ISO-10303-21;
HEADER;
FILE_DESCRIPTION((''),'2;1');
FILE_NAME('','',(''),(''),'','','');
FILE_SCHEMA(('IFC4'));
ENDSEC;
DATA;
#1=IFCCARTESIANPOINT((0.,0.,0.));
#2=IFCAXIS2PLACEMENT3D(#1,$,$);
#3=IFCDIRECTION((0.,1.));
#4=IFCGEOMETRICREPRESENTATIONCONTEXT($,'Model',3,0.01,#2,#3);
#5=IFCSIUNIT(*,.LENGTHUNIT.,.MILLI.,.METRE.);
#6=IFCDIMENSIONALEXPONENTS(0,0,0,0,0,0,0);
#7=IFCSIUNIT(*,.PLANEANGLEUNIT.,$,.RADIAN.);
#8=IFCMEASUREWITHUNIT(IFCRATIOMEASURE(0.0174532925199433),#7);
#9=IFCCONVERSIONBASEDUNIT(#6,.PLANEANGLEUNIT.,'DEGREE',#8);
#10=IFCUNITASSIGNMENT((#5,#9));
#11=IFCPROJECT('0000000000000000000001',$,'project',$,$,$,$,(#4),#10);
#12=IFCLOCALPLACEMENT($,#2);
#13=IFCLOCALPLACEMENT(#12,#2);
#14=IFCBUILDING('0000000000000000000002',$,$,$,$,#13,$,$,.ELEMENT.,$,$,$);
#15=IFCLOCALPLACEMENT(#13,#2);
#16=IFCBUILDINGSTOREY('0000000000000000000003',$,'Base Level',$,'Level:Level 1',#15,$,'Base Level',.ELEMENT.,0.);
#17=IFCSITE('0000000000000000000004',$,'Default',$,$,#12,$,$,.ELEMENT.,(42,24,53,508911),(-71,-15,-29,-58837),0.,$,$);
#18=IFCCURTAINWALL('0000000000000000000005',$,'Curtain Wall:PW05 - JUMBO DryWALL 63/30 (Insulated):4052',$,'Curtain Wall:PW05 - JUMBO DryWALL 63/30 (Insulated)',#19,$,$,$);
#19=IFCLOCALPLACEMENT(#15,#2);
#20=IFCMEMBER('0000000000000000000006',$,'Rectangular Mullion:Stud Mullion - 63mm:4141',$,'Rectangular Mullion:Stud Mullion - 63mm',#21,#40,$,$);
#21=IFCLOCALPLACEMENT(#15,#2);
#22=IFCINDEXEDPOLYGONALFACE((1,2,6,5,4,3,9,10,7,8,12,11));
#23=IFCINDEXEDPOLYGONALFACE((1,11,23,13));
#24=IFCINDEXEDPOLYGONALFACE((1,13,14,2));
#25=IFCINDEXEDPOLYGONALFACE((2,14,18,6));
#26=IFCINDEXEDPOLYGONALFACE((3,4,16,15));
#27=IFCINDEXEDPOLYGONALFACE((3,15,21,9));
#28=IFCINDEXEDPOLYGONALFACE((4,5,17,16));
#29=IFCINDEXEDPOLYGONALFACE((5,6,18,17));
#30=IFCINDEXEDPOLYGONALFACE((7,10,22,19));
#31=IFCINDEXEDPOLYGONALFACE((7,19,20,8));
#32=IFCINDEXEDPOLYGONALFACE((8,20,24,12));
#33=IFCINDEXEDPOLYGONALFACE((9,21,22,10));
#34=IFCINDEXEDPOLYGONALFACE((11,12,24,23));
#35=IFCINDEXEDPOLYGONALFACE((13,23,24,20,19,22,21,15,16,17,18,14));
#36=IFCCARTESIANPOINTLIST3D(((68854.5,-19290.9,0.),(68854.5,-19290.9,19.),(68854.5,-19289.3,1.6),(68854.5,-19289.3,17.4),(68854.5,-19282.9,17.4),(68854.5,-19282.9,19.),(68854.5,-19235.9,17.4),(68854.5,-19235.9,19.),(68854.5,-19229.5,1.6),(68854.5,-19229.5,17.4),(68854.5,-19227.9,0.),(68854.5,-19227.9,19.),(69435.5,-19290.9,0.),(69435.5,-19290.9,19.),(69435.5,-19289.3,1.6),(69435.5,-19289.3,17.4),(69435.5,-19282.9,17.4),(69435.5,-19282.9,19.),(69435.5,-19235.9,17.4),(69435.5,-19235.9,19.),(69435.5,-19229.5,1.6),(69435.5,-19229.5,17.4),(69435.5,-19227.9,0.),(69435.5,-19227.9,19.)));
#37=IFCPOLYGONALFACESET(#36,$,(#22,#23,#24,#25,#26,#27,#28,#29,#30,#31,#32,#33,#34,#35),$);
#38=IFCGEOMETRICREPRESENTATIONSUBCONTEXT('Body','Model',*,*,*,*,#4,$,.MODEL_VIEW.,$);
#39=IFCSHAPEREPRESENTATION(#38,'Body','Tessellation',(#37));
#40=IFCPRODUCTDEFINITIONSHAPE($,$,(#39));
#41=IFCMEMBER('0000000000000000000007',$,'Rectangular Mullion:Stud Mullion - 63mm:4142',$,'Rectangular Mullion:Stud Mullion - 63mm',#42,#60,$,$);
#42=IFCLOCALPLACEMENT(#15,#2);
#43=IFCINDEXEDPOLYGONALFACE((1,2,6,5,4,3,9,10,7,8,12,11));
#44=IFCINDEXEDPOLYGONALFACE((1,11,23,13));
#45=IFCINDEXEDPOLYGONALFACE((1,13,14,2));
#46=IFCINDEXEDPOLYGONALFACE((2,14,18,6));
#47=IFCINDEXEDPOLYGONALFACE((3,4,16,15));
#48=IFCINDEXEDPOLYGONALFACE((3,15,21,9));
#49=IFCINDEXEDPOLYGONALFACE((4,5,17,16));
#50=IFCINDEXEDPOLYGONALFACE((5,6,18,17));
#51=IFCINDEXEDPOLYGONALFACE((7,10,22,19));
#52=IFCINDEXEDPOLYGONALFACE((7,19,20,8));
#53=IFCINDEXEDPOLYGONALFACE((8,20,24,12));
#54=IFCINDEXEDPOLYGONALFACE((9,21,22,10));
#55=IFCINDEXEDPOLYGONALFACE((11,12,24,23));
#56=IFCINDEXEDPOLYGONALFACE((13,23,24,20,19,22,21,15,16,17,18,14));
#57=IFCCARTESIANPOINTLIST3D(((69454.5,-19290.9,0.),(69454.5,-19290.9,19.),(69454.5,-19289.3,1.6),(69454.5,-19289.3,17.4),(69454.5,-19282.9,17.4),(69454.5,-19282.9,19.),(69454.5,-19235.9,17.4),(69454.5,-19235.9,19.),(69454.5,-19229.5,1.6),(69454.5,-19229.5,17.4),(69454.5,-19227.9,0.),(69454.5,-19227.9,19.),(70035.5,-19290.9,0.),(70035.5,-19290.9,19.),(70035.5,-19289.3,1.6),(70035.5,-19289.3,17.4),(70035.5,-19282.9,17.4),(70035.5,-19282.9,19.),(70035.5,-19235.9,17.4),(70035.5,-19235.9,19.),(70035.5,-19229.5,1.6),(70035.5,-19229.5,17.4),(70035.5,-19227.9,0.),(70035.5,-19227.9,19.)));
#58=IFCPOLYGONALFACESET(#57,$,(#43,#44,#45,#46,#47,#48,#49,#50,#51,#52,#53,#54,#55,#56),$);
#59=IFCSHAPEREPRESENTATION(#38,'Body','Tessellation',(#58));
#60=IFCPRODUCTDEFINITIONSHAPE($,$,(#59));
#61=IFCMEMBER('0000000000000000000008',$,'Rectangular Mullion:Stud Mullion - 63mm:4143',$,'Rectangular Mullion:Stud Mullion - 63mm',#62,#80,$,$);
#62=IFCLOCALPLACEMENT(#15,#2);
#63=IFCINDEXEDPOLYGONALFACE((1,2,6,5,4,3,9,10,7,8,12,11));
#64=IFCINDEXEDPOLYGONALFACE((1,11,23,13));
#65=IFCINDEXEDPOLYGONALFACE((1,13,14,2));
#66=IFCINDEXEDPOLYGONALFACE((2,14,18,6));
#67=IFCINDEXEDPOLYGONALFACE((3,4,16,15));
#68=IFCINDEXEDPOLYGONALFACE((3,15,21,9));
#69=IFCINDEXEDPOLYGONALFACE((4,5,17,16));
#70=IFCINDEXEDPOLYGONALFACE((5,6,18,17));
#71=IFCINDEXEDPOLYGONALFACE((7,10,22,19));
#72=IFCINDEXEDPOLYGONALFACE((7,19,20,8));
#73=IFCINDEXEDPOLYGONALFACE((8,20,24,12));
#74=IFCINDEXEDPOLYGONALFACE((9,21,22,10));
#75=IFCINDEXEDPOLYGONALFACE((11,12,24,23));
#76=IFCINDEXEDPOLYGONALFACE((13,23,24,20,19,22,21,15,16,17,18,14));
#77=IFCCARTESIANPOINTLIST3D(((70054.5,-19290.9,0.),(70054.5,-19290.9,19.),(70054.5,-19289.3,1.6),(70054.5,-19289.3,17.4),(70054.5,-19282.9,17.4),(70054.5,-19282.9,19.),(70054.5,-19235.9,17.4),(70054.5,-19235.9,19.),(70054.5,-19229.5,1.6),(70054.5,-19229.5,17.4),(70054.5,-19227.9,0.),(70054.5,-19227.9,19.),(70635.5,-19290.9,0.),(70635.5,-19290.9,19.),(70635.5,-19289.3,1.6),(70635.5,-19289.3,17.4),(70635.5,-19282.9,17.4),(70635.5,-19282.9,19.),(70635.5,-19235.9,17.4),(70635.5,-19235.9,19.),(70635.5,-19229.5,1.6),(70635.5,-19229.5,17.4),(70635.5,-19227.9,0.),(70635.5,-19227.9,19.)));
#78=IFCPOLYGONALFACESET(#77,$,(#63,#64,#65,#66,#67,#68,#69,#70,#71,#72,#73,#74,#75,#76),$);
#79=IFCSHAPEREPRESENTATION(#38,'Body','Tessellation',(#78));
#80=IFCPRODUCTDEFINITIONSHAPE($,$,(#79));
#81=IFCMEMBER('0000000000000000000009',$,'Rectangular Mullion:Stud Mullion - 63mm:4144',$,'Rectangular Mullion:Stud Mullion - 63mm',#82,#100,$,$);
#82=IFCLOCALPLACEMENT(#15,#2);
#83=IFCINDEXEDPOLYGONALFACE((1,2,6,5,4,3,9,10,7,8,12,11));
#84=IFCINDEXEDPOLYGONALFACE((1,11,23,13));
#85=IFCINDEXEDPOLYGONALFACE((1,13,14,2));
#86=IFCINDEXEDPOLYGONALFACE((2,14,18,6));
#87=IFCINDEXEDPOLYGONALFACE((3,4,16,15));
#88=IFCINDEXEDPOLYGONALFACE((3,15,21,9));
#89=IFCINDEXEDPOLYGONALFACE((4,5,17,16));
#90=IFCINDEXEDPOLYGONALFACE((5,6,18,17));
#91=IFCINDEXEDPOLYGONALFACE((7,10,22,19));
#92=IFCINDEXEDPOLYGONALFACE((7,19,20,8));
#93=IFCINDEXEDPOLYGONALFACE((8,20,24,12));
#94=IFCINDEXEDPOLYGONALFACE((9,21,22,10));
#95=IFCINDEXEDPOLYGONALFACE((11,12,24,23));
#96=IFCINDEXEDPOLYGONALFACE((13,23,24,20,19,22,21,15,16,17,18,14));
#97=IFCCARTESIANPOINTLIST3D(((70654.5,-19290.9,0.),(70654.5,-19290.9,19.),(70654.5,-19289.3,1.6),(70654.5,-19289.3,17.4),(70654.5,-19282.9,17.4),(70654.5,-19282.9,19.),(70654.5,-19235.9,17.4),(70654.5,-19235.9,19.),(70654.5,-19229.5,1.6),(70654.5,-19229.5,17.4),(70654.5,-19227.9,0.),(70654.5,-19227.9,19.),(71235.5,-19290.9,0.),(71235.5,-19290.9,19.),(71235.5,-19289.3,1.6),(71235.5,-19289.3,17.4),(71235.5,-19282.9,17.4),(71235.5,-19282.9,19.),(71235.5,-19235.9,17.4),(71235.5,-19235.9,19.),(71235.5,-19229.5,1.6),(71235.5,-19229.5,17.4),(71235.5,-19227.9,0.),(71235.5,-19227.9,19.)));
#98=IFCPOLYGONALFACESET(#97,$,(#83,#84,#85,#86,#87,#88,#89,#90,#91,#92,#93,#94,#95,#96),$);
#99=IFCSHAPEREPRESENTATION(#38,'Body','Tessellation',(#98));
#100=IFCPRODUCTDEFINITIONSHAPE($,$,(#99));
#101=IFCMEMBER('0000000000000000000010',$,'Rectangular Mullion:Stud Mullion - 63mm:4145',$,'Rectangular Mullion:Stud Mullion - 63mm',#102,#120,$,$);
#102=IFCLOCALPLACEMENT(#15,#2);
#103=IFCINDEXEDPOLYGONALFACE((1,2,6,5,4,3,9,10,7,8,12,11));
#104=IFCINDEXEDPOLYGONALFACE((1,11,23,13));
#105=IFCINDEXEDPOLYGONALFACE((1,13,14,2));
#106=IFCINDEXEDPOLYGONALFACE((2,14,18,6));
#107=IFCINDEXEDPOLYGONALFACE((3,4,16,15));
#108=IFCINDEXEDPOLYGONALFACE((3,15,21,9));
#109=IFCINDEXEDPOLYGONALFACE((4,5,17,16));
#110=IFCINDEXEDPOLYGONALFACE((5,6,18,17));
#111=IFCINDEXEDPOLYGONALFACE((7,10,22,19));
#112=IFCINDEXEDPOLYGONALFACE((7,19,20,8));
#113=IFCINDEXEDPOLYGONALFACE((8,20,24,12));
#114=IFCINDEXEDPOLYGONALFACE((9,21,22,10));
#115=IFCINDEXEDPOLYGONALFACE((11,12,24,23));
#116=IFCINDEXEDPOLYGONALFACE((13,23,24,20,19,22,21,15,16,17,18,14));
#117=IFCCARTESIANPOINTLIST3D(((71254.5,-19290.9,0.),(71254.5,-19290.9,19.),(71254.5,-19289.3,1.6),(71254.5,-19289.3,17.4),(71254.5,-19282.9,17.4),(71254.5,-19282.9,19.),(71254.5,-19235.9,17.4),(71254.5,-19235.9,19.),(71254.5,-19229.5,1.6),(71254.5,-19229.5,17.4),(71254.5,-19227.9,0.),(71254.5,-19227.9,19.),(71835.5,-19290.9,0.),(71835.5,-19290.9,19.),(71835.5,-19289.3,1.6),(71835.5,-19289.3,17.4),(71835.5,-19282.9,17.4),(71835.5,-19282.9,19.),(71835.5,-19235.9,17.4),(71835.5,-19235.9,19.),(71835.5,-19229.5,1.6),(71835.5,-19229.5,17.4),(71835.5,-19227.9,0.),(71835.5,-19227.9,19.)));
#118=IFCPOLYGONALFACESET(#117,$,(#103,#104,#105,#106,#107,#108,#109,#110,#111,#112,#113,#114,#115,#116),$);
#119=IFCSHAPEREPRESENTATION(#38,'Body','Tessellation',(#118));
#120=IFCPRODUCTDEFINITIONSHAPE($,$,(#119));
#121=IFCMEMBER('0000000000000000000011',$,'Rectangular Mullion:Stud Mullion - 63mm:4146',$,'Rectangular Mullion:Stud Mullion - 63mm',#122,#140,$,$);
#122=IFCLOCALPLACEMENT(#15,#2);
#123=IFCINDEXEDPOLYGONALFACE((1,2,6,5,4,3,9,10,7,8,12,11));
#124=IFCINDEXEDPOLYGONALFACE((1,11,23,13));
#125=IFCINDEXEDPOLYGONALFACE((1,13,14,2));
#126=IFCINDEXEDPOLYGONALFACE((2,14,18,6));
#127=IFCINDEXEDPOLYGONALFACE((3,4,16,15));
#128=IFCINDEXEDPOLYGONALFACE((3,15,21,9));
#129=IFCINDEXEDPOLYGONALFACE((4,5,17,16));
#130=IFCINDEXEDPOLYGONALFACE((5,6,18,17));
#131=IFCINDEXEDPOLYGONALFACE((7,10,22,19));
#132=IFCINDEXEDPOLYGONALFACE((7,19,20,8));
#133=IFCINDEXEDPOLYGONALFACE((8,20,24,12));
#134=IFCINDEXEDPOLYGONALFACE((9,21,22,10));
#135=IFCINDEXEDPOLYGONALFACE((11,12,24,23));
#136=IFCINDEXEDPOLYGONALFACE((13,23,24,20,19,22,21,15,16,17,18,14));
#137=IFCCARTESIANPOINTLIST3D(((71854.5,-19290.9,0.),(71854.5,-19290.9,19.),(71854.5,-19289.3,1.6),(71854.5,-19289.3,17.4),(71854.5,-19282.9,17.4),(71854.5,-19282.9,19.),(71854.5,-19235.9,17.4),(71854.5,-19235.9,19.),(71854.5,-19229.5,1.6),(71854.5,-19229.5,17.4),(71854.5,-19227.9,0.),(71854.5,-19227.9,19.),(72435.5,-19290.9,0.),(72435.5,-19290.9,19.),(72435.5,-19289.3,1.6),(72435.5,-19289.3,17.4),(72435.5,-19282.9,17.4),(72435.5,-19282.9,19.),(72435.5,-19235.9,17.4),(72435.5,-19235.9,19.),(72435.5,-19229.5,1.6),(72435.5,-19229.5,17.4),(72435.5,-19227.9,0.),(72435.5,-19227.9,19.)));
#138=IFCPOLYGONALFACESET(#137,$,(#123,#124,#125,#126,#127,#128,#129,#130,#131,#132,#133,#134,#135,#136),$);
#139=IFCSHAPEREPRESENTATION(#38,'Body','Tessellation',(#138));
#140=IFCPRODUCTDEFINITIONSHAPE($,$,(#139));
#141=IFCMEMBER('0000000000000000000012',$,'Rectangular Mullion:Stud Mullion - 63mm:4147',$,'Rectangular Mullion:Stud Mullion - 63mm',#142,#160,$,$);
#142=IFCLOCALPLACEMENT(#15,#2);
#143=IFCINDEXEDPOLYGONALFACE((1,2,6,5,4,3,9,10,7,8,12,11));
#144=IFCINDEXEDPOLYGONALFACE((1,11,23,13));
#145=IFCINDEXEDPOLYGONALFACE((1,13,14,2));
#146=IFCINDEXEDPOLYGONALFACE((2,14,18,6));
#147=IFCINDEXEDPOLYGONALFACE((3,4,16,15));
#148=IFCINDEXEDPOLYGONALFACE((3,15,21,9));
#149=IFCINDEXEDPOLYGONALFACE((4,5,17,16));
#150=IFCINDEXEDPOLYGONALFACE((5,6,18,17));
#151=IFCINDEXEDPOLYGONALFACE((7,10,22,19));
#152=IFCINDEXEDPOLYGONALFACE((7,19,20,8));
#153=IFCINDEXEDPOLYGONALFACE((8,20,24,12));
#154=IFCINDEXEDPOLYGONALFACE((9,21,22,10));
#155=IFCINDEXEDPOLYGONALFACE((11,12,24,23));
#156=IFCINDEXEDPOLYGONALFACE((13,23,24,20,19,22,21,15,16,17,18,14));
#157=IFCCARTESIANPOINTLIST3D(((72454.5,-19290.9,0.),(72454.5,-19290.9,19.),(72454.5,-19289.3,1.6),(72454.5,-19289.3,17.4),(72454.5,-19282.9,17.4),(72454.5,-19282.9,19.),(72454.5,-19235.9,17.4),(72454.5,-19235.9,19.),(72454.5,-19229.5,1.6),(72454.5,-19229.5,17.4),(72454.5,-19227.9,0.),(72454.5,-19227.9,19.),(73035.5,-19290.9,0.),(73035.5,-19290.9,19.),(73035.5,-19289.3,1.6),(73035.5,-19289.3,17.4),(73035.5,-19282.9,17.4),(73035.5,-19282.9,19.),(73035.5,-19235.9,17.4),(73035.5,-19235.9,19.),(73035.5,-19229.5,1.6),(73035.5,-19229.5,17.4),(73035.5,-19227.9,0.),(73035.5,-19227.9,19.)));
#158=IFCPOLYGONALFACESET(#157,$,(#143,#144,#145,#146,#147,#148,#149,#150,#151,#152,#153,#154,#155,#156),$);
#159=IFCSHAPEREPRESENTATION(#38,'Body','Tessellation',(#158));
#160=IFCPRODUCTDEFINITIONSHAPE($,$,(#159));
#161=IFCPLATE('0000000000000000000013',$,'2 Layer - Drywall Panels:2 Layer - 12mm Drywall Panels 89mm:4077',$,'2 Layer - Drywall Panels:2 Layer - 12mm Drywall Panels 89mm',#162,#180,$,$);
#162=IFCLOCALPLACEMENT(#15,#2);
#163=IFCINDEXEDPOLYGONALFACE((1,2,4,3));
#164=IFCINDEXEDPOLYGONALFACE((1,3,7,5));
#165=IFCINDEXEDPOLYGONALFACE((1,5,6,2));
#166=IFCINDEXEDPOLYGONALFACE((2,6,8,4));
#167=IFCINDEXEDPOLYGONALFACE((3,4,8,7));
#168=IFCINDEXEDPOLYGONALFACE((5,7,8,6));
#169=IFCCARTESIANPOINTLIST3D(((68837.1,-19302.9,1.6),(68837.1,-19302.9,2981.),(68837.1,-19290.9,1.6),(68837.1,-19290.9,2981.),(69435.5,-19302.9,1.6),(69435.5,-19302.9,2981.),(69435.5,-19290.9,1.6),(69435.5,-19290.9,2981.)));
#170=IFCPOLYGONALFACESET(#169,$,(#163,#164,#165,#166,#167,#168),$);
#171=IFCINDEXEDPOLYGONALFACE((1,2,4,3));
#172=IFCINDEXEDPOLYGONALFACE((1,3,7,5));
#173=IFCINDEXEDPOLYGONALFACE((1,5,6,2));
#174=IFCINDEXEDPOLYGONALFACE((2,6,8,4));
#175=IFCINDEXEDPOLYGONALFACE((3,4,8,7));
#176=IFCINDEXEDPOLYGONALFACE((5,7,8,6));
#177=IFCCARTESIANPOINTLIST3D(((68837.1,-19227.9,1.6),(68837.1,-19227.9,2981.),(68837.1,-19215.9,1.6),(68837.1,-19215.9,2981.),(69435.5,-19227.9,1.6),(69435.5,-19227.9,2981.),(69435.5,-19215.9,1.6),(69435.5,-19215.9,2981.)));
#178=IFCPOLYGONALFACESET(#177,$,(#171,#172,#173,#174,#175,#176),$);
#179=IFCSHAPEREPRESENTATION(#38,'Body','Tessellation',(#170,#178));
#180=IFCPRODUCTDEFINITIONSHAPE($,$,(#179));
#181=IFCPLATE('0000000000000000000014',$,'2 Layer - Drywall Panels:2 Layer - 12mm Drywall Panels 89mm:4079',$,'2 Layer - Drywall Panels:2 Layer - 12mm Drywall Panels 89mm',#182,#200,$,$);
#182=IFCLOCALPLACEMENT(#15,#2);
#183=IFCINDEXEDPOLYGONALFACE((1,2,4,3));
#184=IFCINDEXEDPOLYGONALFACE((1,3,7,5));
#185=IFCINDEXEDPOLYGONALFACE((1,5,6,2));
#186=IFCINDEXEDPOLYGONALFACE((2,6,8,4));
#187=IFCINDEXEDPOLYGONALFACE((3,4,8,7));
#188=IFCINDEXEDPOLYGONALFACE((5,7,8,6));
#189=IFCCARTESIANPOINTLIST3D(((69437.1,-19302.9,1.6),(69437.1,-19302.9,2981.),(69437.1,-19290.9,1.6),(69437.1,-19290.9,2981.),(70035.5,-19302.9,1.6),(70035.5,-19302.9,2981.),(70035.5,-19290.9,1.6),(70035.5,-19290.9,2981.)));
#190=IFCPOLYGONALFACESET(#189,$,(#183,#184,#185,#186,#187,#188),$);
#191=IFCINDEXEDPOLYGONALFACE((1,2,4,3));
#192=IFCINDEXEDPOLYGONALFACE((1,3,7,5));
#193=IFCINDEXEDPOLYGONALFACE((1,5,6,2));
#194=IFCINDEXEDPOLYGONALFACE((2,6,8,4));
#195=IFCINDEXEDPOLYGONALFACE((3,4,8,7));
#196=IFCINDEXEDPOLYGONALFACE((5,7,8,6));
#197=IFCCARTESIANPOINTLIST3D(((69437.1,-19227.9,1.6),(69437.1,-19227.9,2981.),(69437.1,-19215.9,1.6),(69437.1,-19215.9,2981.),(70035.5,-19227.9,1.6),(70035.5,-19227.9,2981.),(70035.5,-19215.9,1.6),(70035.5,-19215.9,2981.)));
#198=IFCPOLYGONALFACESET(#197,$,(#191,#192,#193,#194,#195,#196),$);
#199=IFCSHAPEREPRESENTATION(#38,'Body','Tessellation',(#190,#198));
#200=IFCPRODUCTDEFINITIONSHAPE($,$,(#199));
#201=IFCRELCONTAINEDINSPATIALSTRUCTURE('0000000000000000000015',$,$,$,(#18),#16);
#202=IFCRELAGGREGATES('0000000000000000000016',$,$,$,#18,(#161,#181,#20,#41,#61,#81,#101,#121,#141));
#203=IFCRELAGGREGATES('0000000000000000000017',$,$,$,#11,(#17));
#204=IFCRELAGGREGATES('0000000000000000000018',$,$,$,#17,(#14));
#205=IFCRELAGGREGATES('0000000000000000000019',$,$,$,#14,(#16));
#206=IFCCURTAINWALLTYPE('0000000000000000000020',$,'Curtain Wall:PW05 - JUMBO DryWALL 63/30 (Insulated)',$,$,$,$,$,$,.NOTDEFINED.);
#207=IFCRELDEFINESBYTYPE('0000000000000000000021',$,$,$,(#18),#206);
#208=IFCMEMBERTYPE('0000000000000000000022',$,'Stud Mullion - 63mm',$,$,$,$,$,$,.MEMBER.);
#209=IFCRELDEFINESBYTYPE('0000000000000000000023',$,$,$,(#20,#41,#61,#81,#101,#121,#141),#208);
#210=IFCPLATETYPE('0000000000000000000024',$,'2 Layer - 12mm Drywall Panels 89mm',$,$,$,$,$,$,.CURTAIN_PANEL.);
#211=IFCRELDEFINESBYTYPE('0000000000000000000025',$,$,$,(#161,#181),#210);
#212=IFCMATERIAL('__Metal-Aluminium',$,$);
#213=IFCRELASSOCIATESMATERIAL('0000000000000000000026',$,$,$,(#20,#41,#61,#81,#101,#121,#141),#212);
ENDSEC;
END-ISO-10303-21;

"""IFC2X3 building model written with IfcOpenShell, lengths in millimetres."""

from ifc_helpers import new_model, entity, si_unit, converted_unit, direction, frame, frame_2d, origin, place, context, subcontext, project, spatial, polyline, rectangle, outline, extrude, source, transform, mapped, material, type_object, type_shapes, element, aggregate, save


model = new_model("IFC2X3")

# Units and contexts
model_context = context("Model", 3, precision=0.01, world=origin(), true_north=direction((0.0, 1.0)))
body_context = subcontext(model_context, "Body", "Model", "MODEL_VIEW")
ifc_project = project(units=[si_unit("LENGTHUNIT", "METRE", prefix="MILLI"), converted_unit("PLANEANGLEUNIT", "DEGREE", entity("IfcRatioMeasure", 0.0174532925199433), si_unit("PLANEANGLEUNIT", "RADIAN"), dimensions=[0, 0, 0, 0, 0, 0, 0])], contexts=[model_context])

# Site, building, storey
site_placement = place(None, origin())
site = spatial("IfcSite", under=ifc_project, at=site_placement, Name="Default", CompositionType="ELEMENT", RefLatitude=(42, 24, 53, 508911), RefLongitude=(-71, -15, -29, -58837), RefElevation=0.0)
building_placement = place(site_placement, origin())
building = spatial("IfcBuilding", under=site, at=building_placement, CompositionType="ELEMENT")
storey_placement = place(building_placement, origin())
storey = spatial("IfcBuildingStorey", under=building, at=storey_placement, Name="Base Level", ObjectType="Level:Level 1", LongName="Base Level", CompositionType="ELEMENT", Elevation=0.0)

# Curtain wall, members, plates
curtain_wall_type = type_object("IfcCurtainWallType", Name="Curtain Wall:PW05 - JUMBO DryWALL 63/30 (Insulated)", PredefinedType="NOTDEFINED")
curtain_wall_placement = place(building_placement, origin())
curtain_wall = element("IfcCurtainWall", 1, at=curtain_wall_placement, inside=storey, type_object=curtain_wall_type, Name="Curtain Wall:PW05 - JUMBO DryWALL 63/30 (Insulated):4052", ObjectType="Curtain Wall:PW05 - JUMBO DryWALL 63/30 (Insulated)")
ifc_material = material(Name="__Metal-Aluminium")
member_type_1 = type_object("IfcMemberType", Name="Stud Mullion - 63mm", PredefinedType="MEMBER")
shared_shape_1 = source(origin(), body_context, "Body", "SweptSolid", [
    extrude(outline(polyline([(23.5, -6.6), (31.5, -6.6), (31.5, 12.4), (-31.5, 12.4), (-31.5, -6.6), (-23.5, -6.6), (-23.5, -5.0), (-29.9, -5.0), (-29.9, 10.8), (29.9, 10.8), (29.9, -5.0), (23.5, -5.0), (23.5, -6.6)])), frame((-12.4, 0.0, -581.0), z_axis=(0.0, 0.0, 1.0), x_axis=(0.0, -1.0, 0.0)), (0.0, 0.0, 1.0), 581.0),
])
type_shapes(member_type_1, [shared_shape_1])
member_1_placement = place(building_placement, frame((68854.5, -19259.4, 0.0), z_axis=(-1.0, 0.0, 0.0), x_axis=(0.0, 0.0, -1.0)))
member_1 = element("IfcMember", 2, at=member_1_placement, type_object=member_type_1, material=ifc_material, Name="Rectangular Mullion:Stud Mullion - 63mm:4141", ObjectType="Rectangular Mullion:Stud Mullion - 63mm", context=body_context, shape_type="MappedRepresentation", body=[
    mapped(shared_shape_1, transform((0.0, 0.0, 0.0), scale=1.0)),
])
member_2_placement = place(building_placement, frame((69454.5, -19259.4, 0.0), z_axis=(-1.0, 0.0, 0.0), x_axis=(0.0, 0.0, -1.0)))
member_2 = element("IfcMember", 3, at=member_2_placement, type_object=member_type_1, material=ifc_material, Name="Rectangular Mullion:Stud Mullion - 63mm:4142", ObjectType="Rectangular Mullion:Stud Mullion - 63mm", context=body_context, shape_type="MappedRepresentation", body=[
    mapped(shared_shape_1, transform((0.0, 0.0, 0.0), scale=1.0)),
])
member_3_placement = place(building_placement, frame((70054.5, -19259.4, 0.0), z_axis=(-1.0, 0.0, 0.0), x_axis=(0.0, 0.0, -1.0)))
member_3 = element("IfcMember", 4, at=member_3_placement, type_object=member_type_1, material=ifc_material, Name="Rectangular Mullion:Stud Mullion - 63mm:4143", ObjectType="Rectangular Mullion:Stud Mullion - 63mm", context=body_context, shape_type="MappedRepresentation", body=[
    mapped(shared_shape_1, transform((0.0, 0.0, 0.0), scale=1.0)),
])
member_4_placement = place(building_placement, frame((70654.5, -19259.4, 0.0), z_axis=(-1.0, 0.0, 0.0), x_axis=(0.0, 0.0, -1.0)))
member_4 = element("IfcMember", 5, at=member_4_placement, type_object=member_type_1, material=ifc_material, Name="Rectangular Mullion:Stud Mullion - 63mm:4144", ObjectType="Rectangular Mullion:Stud Mullion - 63mm", context=body_context, shape_type="MappedRepresentation", body=[
    mapped(shared_shape_1, transform((0.0, 0.0, 0.0), scale=1.0)),
])
member_5_placement = place(building_placement, frame((71254.5, -19259.4, 0.0), z_axis=(-1.0, 0.0, 0.0), x_axis=(0.0, 0.0, -1.0)))
member_5 = element("IfcMember", 6, at=member_5_placement, type_object=member_type_1, material=ifc_material, Name="Rectangular Mullion:Stud Mullion - 63mm:4145", ObjectType="Rectangular Mullion:Stud Mullion - 63mm", context=body_context, shape_type="MappedRepresentation", body=[
    mapped(shared_shape_1, transform((0.0, 0.0, 0.0), scale=1.0)),
])
member_6_placement = place(building_placement, frame((71854.5, -19259.4, 0.0), z_axis=(-1.0, 0.0, 0.0), x_axis=(0.0, 0.0, -1.0)))
member_6 = element("IfcMember", 7, at=member_6_placement, type_object=member_type_1, material=ifc_material, Name="Rectangular Mullion:Stud Mullion - 63mm:4146", ObjectType="Rectangular Mullion:Stud Mullion - 63mm", context=body_context, shape_type="MappedRepresentation", body=[
    mapped(shared_shape_1, transform((0.0, 0.0, 0.0), scale=1.0)),
])
member_7_placement = place(building_placement, frame((72454.5, -19259.4, 0.0), z_axis=(-1.0, 0.0, 0.0), x_axis=(0.0, 0.0, -1.0)))
member_7 = element("IfcMember", 8, at=member_7_placement, type_object=member_type_1, material=ifc_material, Name="Rectangular Mullion:Stud Mullion - 63mm:4147", ObjectType="Rectangular Mullion:Stud Mullion - 63mm", context=body_context, shape_type="MappedRepresentation", body=[
    mapped(shared_shape_1, transform((0.0, 0.0, 0.0), scale=1.0)),
])
plate_type = type_object("IfcPlateType", Name="2 Layer - 12mm Drywall Panels 89mm", PredefinedType="CURTAIN_PANEL")
shared_shape_2 = source(origin(), body_context, "Body", "SweptSolid", [
    extrude(rectangle(XDim=598.4, YDim=12.0, at=frame_2d((0.0, 0.0), x_axis=(1.0, 0.0))), frame((0.0, -37.5, 0.0), z_axis=(0.0, 0.0, 1.0), x_axis=(-1.0, 0.0, 0.0)), (0.0, 0.0, 1.0), 2979.4),
    extrude(rectangle(XDim=12.0, YDim=598.4, at=frame_2d((0.0, 0.0), x_axis=(1.0, 0.0))), frame((0.0, 37.5, 0.0), z_axis=(0.0, 0.0, 1.0), x_axis=(0.0, 1.0, 0.0)), (0.0, 0.0, 1.0), 2979.4),
])
type_shapes(plate_type, [shared_shape_2])
plate_1_placement = place(curtain_wall_placement, frame((69136.3, -19259.4, 1.6)))
plate_1 = element("IfcPlate", 9, at=plate_1_placement, type_object=plate_type, Name="2 Layer - Drywall Panels:2 Layer - 12mm Drywall Panels 89mm:4077", ObjectType="2 Layer - Drywall Panels:2 Layer - 12mm Drywall Panels 89mm", context=body_context, shape_type="MappedRepresentation", body=[
    mapped(shared_shape_2, transform((0.0, 0.0, 0.0), scale=1.0)),
])
plate_2_placement = place(curtain_wall_placement, frame((69736.3, -19259.4, 1.6)))
plate_2 = element("IfcPlate", 10, at=plate_2_placement, type_object=plate_type, Name="2 Layer - Drywall Panels:2 Layer - 12mm Drywall Panels 89mm:4079", ObjectType="2 Layer - Drywall Panels:2 Layer - 12mm Drywall Panels 89mm", context=body_context, shape_type="MappedRepresentation", body=[
    mapped(shared_shape_2, transform((0.0, 0.0, 0.0), scale=1.0)),
])
aggregate(curtain_wall, [plate_1, plate_2, member_1, member_2, member_3, member_4, member_5, member_6, member_7])

save(model, "model.ifc")
